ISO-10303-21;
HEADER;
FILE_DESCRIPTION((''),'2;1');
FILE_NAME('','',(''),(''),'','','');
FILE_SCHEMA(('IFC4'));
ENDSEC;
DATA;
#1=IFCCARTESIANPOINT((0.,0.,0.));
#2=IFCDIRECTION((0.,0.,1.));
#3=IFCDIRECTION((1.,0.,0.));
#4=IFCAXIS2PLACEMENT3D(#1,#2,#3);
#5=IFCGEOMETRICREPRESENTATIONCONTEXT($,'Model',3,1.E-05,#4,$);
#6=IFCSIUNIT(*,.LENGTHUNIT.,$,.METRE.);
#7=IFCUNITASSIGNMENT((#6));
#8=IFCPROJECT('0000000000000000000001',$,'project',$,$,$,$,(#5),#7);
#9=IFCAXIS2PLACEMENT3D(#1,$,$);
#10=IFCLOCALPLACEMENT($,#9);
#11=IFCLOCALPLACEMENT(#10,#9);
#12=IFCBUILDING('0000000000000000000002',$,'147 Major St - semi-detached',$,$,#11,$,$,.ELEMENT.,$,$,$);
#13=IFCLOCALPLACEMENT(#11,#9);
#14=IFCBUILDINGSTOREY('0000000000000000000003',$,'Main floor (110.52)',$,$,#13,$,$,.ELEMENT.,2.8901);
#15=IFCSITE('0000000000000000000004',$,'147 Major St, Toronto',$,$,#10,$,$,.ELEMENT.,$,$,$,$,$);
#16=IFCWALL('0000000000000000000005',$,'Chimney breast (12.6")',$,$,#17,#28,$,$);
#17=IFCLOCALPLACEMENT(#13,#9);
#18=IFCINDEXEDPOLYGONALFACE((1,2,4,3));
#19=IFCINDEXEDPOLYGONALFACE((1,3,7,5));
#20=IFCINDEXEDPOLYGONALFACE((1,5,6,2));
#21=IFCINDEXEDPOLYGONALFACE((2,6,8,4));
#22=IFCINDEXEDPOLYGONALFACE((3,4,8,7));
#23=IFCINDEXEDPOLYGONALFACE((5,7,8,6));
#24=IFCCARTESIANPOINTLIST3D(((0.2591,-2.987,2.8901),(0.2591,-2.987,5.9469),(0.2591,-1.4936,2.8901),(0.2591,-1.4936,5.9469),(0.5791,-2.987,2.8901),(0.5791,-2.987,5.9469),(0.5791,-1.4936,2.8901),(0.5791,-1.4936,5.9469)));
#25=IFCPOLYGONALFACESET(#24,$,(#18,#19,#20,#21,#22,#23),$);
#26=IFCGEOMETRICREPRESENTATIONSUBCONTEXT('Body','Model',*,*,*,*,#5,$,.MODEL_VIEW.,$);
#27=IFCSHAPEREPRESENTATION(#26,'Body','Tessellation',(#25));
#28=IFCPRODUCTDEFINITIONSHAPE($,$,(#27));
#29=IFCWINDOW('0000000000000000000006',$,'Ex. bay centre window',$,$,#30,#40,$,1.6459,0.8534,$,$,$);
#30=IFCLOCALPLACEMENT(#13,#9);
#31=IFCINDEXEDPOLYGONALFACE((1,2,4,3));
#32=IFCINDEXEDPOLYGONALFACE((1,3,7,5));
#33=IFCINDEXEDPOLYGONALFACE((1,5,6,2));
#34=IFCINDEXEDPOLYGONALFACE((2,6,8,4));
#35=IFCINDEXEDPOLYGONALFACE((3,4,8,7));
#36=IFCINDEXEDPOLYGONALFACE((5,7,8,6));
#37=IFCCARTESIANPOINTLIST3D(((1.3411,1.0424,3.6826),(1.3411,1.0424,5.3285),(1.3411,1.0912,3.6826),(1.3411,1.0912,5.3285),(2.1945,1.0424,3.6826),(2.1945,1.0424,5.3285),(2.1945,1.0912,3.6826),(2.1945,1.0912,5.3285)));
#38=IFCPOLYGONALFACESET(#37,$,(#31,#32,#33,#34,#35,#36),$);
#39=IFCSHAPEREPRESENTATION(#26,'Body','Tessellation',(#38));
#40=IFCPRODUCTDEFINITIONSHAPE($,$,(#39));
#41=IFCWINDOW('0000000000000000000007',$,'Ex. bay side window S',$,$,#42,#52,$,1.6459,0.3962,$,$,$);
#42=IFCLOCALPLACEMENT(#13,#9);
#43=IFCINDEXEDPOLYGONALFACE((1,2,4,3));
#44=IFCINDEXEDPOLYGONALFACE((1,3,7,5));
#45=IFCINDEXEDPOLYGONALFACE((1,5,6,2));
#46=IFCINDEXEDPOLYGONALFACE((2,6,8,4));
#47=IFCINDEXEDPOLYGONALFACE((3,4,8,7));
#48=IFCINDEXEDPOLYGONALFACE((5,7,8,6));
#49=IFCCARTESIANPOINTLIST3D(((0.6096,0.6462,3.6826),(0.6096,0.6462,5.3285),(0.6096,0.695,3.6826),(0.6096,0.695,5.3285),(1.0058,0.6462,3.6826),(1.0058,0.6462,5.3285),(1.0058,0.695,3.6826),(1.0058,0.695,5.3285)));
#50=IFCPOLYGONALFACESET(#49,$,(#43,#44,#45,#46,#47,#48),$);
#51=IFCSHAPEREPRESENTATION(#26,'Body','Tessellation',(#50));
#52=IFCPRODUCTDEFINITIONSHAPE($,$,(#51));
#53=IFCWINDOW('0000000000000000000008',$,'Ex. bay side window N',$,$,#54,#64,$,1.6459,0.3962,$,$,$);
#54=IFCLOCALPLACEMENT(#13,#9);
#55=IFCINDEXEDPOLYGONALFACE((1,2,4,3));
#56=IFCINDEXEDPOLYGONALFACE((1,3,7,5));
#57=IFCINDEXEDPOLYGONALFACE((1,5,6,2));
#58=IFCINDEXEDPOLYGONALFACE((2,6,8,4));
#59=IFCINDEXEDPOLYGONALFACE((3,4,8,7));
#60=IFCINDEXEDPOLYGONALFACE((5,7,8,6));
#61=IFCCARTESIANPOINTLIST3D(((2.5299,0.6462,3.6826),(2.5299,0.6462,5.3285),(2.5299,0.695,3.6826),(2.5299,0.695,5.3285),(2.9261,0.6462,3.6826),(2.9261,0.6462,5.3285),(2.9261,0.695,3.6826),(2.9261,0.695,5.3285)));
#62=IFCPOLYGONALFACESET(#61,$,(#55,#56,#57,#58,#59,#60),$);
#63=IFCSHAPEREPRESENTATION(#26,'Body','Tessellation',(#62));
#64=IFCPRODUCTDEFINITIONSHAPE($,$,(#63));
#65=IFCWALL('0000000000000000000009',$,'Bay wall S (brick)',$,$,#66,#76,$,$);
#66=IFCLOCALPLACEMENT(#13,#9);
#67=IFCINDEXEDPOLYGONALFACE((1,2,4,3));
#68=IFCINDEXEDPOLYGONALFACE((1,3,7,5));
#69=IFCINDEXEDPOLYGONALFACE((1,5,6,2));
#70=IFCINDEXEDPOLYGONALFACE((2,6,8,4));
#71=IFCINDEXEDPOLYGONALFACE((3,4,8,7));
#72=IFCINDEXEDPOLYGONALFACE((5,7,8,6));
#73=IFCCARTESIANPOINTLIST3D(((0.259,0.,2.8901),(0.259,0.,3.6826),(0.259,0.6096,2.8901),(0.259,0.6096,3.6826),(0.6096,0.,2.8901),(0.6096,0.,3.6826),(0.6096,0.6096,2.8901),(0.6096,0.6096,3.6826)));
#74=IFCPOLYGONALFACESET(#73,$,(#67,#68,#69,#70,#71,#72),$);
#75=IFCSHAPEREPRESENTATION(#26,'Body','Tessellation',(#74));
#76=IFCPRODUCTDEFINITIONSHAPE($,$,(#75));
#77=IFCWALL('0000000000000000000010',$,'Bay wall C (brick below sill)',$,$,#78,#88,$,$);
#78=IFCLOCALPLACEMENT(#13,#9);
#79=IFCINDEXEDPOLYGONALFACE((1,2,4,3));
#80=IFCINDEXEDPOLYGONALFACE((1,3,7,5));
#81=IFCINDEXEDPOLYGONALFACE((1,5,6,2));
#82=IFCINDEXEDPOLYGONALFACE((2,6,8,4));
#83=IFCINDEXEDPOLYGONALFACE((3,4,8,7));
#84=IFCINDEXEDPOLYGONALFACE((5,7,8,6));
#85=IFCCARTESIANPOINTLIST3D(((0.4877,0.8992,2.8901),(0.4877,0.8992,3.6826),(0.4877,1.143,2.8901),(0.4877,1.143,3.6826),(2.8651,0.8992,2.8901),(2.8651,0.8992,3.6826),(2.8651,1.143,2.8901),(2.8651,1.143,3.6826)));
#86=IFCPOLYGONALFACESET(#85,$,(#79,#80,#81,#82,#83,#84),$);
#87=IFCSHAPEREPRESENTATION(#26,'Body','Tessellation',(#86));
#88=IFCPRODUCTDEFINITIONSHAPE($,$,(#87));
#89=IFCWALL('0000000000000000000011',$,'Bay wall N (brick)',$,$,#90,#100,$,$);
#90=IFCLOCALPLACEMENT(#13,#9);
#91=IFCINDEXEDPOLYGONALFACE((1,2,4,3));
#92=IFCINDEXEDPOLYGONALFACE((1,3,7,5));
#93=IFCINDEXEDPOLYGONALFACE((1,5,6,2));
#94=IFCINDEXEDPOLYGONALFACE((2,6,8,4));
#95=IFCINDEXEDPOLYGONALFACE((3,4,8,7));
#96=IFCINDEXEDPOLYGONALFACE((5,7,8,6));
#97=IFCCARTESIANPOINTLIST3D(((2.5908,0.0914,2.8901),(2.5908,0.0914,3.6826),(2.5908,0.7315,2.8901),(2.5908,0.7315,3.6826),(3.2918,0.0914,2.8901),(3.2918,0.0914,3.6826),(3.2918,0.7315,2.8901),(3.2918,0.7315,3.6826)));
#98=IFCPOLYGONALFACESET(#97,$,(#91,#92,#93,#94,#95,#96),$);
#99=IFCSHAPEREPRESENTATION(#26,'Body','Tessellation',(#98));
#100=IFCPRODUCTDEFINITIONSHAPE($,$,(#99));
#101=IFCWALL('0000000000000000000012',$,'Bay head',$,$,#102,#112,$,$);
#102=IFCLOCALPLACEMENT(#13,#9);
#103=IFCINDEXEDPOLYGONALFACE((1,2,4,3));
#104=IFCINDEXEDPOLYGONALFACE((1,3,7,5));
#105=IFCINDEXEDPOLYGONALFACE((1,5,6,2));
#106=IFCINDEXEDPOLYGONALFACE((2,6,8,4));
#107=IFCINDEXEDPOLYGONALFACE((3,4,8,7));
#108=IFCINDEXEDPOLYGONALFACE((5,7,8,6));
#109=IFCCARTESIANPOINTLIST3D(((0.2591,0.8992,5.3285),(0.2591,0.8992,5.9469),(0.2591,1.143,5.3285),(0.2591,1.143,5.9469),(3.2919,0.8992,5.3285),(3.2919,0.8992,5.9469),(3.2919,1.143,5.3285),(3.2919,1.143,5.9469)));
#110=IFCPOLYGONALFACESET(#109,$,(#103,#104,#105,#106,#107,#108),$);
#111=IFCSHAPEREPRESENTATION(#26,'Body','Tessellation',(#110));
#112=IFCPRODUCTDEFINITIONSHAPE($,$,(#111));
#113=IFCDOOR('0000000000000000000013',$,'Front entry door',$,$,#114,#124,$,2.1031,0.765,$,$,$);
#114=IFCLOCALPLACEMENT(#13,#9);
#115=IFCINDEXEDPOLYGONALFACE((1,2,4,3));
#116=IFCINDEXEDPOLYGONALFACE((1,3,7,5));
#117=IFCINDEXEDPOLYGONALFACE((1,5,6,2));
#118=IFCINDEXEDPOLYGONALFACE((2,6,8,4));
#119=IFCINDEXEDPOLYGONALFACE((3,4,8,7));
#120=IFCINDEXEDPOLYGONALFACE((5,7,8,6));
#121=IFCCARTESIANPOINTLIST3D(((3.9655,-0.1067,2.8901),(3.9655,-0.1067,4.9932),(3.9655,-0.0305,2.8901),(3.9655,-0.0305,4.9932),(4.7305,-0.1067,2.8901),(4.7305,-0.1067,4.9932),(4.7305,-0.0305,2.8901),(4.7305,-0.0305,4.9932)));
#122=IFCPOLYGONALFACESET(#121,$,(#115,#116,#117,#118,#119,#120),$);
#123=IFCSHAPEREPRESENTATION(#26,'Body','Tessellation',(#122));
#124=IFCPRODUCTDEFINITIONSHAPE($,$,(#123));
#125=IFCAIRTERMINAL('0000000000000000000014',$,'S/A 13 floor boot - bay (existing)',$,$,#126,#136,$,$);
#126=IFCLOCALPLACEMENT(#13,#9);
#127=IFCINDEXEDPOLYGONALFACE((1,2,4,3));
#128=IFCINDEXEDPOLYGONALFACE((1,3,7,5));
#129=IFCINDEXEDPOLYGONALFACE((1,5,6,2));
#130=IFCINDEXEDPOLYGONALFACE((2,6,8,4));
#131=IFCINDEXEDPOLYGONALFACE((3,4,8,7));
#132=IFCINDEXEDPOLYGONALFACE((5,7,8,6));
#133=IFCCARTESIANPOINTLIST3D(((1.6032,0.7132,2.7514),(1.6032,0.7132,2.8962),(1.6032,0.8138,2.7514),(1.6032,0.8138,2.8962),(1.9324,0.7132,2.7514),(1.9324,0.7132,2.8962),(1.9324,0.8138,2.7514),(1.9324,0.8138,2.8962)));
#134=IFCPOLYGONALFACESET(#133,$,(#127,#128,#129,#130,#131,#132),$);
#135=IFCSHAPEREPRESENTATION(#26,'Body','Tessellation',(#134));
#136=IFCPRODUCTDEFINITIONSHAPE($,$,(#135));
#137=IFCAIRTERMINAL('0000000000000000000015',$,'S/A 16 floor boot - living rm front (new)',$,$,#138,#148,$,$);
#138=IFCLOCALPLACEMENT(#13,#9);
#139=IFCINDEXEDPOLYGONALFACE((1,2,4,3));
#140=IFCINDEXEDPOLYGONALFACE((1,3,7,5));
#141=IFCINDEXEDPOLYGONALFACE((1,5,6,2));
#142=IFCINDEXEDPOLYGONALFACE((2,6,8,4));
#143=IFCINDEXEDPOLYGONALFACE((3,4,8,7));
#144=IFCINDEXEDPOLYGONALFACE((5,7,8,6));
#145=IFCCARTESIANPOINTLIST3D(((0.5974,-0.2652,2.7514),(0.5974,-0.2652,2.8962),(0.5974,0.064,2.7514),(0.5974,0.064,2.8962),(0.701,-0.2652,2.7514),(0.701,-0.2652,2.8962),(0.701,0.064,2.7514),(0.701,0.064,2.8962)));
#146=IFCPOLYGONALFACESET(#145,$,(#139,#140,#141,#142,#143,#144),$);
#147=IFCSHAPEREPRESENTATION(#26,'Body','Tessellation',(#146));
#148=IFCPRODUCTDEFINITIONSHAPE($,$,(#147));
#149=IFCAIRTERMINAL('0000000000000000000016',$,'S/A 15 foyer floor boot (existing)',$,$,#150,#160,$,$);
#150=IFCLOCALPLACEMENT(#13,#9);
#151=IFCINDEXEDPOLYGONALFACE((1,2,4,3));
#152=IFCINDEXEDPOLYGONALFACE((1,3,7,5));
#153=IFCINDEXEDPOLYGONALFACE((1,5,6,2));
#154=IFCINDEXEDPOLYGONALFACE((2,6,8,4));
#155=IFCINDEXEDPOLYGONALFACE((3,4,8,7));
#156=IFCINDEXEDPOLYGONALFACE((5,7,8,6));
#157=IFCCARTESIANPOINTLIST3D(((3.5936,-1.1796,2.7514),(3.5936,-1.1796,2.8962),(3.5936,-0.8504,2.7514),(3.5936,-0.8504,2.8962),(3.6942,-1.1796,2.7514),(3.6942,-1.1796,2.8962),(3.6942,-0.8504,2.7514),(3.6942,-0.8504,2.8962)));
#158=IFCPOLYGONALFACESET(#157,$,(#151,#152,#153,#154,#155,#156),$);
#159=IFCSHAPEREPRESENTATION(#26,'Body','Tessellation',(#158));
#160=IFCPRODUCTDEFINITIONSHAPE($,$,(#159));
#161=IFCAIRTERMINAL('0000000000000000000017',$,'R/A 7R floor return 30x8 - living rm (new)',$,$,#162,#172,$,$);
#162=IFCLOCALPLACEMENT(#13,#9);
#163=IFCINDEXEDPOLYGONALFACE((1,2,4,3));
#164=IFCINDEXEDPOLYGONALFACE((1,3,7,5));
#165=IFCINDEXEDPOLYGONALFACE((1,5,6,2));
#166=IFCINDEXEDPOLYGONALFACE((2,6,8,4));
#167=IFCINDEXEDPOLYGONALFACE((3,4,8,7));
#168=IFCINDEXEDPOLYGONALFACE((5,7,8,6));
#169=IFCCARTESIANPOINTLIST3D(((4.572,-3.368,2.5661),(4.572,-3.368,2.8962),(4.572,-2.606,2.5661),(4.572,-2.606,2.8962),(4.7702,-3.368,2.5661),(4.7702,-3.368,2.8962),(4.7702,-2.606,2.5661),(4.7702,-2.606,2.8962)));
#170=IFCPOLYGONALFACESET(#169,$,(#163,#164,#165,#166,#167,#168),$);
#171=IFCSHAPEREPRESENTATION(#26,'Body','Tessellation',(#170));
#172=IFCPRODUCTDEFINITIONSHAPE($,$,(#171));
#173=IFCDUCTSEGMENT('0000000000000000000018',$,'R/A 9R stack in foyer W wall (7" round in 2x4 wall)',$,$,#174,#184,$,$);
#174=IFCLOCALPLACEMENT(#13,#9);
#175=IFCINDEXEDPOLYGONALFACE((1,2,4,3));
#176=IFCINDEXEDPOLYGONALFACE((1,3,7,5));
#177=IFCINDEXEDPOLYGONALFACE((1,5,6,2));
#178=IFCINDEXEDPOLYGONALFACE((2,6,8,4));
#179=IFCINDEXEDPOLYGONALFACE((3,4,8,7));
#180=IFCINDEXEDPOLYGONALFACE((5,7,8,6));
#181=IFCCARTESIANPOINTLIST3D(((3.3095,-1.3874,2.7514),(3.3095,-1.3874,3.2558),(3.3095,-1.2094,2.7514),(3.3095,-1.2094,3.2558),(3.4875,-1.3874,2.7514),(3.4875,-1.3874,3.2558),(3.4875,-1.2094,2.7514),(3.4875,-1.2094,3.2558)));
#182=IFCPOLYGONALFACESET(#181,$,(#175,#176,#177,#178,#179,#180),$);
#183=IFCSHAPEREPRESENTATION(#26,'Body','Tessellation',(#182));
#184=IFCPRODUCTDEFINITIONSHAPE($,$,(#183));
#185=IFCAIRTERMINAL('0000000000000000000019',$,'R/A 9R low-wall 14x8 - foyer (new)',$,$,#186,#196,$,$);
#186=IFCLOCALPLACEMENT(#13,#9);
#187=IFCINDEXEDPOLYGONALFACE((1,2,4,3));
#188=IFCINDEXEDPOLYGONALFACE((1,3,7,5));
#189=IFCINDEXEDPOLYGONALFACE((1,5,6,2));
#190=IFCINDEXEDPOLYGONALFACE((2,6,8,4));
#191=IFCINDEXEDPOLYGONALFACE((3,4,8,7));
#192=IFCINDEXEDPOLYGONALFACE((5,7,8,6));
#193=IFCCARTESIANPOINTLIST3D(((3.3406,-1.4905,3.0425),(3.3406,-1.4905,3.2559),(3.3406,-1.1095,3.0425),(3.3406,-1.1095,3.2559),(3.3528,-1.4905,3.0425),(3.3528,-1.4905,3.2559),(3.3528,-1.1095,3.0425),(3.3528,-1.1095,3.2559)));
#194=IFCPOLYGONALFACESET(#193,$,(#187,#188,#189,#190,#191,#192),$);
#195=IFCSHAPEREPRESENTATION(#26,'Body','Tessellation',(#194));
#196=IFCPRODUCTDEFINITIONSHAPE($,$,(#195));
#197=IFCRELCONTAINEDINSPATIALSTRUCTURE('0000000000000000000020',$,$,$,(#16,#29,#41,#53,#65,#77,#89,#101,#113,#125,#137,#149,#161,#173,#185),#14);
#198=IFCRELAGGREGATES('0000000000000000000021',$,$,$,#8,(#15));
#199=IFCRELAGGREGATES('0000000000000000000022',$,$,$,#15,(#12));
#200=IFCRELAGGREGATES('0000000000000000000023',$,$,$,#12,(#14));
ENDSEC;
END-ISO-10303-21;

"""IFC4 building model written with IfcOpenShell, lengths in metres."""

from ifc_helpers import new_model, si_unit, frame, origin, origin_with_axes, place, context, subcontext, project, spatial, rectangle, extrude, element, save


model = new_model("IFC4")

# Units and contexts
model_context = context("Model", 3, precision=1e-05, world=origin_with_axes())
body_context = subcontext(model_context, "Body", "Model", "MODEL_VIEW")
ifc_project = project(units=[si_unit("LENGTHUNIT", "METRE")], contexts=[model_context])

# Site, building, storey
site_placement = place(None, origin())
site = spatial("IfcSite", under=ifc_project, at=site_placement, Name="147 Major St, Toronto", CompositionType="ELEMENT")
building_placement = place(site_placement, origin())
building = spatial("IfcBuilding", under=site, at=building_placement, Name="147 Major St - semi-detached", CompositionType="ELEMENT")
storey_placement = place(building_placement, origin())
storey = spatial("IfcBuildingStorey", under=building, at=storey_placement, Name="Main floor (110.52)", CompositionType="ELEMENT", Elevation=2.8901)

# Wall
wall_1_placement = place(storey_placement, frame((0.4191, -2.2403, 2.8901)))
element("IfcWall", 1, at=wall_1_placement, inside=storey, Name="Chimney breast (12.6\")", context=body_context, shape_type="SweptSolid", body=[
    extrude(rectangle(XDim=0.32, YDim=1.4935), origin_with_axes(), (0.0, 0.0, 1.0), 3.0568),
])

# Windows
window_placement = place(storey_placement, frame((1.7678, 1.0668, 3.6826)))
element("IfcWindow", 2, at=window_placement, inside=storey, Name="Ex. bay centre window", OverallHeight=1.6459, OverallWidth=0.8534, context=body_context, shape_type="SweptSolid", body=[
    extrude(rectangle(XDim=0.8534, YDim=0.0488), origin_with_axes(), (0.0, 0.0, 1.0), 1.6459),
])
for number, where, name in (
    (3, (0.8077, 0.6706, 3.6826), "Ex. bay side window S"),
    (4, (2.728, 0.6706, 3.6826), "Ex. bay side window N"),
):
    element("IfcWindow", number, at=place(storey_placement, frame(where)), inside=storey, Name=name, OverallHeight=1.6459, OverallWidth=0.3962, context=body_context, shape_type="SweptSolid", body=[
        extrude(rectangle(XDim=0.3962, YDim=0.0488), origin_with_axes(), (0.0, 0.0, 1.0), 1.6459),
    ])

# Walls
wall_2_placement = place(storey_placement, frame((0.4343, 0.3048, 2.8901)))
element("IfcWall", 5, at=wall_2_placement, inside=storey, Name="Bay wall S (brick)", context=body_context, shape_type="SweptSolid", body=[
    extrude(rectangle(XDim=0.3505, YDim=0.6096), origin_with_axes(), (0.0, 0.0, 1.0), 0.7925),
])
wall_3_placement = place(storey_placement, frame((1.6764, 1.0211, 2.8901)))
element("IfcWall", 6, at=wall_3_placement, inside=storey, Name="Bay wall C (brick below sill)", context=body_context, shape_type="SweptSolid", body=[
    extrude(rectangle(XDim=2.3774, YDim=0.2438), origin_with_axes(), (0.0, 0.0, 1.0), 0.7925),
])
wall_4_placement = place(storey_placement, frame((2.9413, 0.4115, 2.8901)))
element("IfcWall", 7, at=wall_4_placement, inside=storey, Name="Bay wall N (brick)", context=body_context, shape_type="SweptSolid", body=[
    extrude(rectangle(XDim=0.701, YDim=0.6401), origin_with_axes(), (0.0, 0.0, 1.0), 0.7925),
])
wall_5_placement = place(storey_placement, frame((1.7755, 1.0211, 5.3285)))
element("IfcWall", 8, at=wall_5_placement, inside=storey, Name="Bay head", context=body_context, shape_type="SweptSolid", body=[
    extrude(rectangle(XDim=3.0328, YDim=0.2438), origin_with_axes(), (0.0, 0.0, 1.0), 0.6184),
])

# Door
door_placement = place(storey_placement, frame((4.348, -0.0686, 2.8901)))
element("IfcDoor", 9, at=door_placement, inside=storey, Name="Front entry door", OverallHeight=2.1031, OverallWidth=0.765, context=body_context, shape_type="SweptSolid", body=[
    extrude(rectangle(XDim=0.765, YDim=0.0762), origin_with_axes(), (0.0, 0.0, 1.0), 2.1031),
])

# Air terminals
air_terminal_1_placement = place(storey_placement, frame((1.7678, 0.7635, 2.7514)))
element("IfcAirTerminal", 10, at=air_terminal_1_placement, inside=storey, Name="S/A 13 floor boot - bay (existing)", context=body_context, shape_type="SweptSolid", body=[
    extrude(rectangle(XDim=0.3292, YDim=0.1006), origin_with_axes(), (0.0, 0.0, 1.0), 0.1448),
])
air_terminal_2_placement = place(storey_placement, frame((0.6492, -0.1006, 2.7514)))
element("IfcAirTerminal", 11, at=air_terminal_2_placement, inside=storey, Name="S/A 16 floor boot - living rm front (new)", context=body_context, shape_type="SweptSolid", body=[
    extrude(rectangle(XDim=0.1036, YDim=0.3292), origin_with_axes(), (0.0, 0.0, 1.0), 0.1448),
])
air_terminal_3_placement = place(storey_placement, frame((3.6439, -1.015, 2.7514)))
element("IfcAirTerminal", 12, at=air_terminal_3_placement, inside=storey, Name="S/A 15 foyer floor boot (existing)", context=body_context, shape_type="SweptSolid", body=[
    extrude(rectangle(XDim=0.1006, YDim=0.3292), origin_with_axes(), (0.0, 0.0, 1.0), 0.1448),
])
air_terminal_4_placement = place(storey_placement, frame((4.6711, -2.987, 2.5661)))
element("IfcAirTerminal", 13, at=air_terminal_4_placement, inside=storey, Name="R/A 7R floor return 30x8 - living rm (new)", context=body_context, shape_type="SweptSolid", body=[
    extrude(rectangle(XDim=0.1981, YDim=0.762), origin_with_axes(), (0.0, 0.0, 1.0), 0.3301),
])

# Duct segment
duct_segment_placement = place(storey_placement, frame((3.3985, -1.2984, 2.7514)))
element("IfcDuctSegment", 14, at=duct_segment_placement, inside=storey, Name="R/A 9R stack in foyer W wall (7\" round in 2x4 wall)", context=body_context, shape_type="SweptSolid", body=[
    extrude(rectangle(XDim=0.178, YDim=0.178), origin_with_axes(), (0.0, 0.0, 1.0), 0.5044),
])

# Air terminal
air_terminal_5_placement = place(storey_placement, frame((3.3467, -1.3, 3.0425)))
element("IfcAirTerminal", 15, at=air_terminal_5_placement, inside=storey, Name="R/A 9R low-wall 14x8 - foyer (new)", context=body_context, shape_type="SweptSolid", body=[
    extrude(rectangle(XDim=0.0122, YDim=0.381), origin_with_axes(), (0.0, 0.0, 1.0), 0.2134),
])

save(model, "model.ifc")
